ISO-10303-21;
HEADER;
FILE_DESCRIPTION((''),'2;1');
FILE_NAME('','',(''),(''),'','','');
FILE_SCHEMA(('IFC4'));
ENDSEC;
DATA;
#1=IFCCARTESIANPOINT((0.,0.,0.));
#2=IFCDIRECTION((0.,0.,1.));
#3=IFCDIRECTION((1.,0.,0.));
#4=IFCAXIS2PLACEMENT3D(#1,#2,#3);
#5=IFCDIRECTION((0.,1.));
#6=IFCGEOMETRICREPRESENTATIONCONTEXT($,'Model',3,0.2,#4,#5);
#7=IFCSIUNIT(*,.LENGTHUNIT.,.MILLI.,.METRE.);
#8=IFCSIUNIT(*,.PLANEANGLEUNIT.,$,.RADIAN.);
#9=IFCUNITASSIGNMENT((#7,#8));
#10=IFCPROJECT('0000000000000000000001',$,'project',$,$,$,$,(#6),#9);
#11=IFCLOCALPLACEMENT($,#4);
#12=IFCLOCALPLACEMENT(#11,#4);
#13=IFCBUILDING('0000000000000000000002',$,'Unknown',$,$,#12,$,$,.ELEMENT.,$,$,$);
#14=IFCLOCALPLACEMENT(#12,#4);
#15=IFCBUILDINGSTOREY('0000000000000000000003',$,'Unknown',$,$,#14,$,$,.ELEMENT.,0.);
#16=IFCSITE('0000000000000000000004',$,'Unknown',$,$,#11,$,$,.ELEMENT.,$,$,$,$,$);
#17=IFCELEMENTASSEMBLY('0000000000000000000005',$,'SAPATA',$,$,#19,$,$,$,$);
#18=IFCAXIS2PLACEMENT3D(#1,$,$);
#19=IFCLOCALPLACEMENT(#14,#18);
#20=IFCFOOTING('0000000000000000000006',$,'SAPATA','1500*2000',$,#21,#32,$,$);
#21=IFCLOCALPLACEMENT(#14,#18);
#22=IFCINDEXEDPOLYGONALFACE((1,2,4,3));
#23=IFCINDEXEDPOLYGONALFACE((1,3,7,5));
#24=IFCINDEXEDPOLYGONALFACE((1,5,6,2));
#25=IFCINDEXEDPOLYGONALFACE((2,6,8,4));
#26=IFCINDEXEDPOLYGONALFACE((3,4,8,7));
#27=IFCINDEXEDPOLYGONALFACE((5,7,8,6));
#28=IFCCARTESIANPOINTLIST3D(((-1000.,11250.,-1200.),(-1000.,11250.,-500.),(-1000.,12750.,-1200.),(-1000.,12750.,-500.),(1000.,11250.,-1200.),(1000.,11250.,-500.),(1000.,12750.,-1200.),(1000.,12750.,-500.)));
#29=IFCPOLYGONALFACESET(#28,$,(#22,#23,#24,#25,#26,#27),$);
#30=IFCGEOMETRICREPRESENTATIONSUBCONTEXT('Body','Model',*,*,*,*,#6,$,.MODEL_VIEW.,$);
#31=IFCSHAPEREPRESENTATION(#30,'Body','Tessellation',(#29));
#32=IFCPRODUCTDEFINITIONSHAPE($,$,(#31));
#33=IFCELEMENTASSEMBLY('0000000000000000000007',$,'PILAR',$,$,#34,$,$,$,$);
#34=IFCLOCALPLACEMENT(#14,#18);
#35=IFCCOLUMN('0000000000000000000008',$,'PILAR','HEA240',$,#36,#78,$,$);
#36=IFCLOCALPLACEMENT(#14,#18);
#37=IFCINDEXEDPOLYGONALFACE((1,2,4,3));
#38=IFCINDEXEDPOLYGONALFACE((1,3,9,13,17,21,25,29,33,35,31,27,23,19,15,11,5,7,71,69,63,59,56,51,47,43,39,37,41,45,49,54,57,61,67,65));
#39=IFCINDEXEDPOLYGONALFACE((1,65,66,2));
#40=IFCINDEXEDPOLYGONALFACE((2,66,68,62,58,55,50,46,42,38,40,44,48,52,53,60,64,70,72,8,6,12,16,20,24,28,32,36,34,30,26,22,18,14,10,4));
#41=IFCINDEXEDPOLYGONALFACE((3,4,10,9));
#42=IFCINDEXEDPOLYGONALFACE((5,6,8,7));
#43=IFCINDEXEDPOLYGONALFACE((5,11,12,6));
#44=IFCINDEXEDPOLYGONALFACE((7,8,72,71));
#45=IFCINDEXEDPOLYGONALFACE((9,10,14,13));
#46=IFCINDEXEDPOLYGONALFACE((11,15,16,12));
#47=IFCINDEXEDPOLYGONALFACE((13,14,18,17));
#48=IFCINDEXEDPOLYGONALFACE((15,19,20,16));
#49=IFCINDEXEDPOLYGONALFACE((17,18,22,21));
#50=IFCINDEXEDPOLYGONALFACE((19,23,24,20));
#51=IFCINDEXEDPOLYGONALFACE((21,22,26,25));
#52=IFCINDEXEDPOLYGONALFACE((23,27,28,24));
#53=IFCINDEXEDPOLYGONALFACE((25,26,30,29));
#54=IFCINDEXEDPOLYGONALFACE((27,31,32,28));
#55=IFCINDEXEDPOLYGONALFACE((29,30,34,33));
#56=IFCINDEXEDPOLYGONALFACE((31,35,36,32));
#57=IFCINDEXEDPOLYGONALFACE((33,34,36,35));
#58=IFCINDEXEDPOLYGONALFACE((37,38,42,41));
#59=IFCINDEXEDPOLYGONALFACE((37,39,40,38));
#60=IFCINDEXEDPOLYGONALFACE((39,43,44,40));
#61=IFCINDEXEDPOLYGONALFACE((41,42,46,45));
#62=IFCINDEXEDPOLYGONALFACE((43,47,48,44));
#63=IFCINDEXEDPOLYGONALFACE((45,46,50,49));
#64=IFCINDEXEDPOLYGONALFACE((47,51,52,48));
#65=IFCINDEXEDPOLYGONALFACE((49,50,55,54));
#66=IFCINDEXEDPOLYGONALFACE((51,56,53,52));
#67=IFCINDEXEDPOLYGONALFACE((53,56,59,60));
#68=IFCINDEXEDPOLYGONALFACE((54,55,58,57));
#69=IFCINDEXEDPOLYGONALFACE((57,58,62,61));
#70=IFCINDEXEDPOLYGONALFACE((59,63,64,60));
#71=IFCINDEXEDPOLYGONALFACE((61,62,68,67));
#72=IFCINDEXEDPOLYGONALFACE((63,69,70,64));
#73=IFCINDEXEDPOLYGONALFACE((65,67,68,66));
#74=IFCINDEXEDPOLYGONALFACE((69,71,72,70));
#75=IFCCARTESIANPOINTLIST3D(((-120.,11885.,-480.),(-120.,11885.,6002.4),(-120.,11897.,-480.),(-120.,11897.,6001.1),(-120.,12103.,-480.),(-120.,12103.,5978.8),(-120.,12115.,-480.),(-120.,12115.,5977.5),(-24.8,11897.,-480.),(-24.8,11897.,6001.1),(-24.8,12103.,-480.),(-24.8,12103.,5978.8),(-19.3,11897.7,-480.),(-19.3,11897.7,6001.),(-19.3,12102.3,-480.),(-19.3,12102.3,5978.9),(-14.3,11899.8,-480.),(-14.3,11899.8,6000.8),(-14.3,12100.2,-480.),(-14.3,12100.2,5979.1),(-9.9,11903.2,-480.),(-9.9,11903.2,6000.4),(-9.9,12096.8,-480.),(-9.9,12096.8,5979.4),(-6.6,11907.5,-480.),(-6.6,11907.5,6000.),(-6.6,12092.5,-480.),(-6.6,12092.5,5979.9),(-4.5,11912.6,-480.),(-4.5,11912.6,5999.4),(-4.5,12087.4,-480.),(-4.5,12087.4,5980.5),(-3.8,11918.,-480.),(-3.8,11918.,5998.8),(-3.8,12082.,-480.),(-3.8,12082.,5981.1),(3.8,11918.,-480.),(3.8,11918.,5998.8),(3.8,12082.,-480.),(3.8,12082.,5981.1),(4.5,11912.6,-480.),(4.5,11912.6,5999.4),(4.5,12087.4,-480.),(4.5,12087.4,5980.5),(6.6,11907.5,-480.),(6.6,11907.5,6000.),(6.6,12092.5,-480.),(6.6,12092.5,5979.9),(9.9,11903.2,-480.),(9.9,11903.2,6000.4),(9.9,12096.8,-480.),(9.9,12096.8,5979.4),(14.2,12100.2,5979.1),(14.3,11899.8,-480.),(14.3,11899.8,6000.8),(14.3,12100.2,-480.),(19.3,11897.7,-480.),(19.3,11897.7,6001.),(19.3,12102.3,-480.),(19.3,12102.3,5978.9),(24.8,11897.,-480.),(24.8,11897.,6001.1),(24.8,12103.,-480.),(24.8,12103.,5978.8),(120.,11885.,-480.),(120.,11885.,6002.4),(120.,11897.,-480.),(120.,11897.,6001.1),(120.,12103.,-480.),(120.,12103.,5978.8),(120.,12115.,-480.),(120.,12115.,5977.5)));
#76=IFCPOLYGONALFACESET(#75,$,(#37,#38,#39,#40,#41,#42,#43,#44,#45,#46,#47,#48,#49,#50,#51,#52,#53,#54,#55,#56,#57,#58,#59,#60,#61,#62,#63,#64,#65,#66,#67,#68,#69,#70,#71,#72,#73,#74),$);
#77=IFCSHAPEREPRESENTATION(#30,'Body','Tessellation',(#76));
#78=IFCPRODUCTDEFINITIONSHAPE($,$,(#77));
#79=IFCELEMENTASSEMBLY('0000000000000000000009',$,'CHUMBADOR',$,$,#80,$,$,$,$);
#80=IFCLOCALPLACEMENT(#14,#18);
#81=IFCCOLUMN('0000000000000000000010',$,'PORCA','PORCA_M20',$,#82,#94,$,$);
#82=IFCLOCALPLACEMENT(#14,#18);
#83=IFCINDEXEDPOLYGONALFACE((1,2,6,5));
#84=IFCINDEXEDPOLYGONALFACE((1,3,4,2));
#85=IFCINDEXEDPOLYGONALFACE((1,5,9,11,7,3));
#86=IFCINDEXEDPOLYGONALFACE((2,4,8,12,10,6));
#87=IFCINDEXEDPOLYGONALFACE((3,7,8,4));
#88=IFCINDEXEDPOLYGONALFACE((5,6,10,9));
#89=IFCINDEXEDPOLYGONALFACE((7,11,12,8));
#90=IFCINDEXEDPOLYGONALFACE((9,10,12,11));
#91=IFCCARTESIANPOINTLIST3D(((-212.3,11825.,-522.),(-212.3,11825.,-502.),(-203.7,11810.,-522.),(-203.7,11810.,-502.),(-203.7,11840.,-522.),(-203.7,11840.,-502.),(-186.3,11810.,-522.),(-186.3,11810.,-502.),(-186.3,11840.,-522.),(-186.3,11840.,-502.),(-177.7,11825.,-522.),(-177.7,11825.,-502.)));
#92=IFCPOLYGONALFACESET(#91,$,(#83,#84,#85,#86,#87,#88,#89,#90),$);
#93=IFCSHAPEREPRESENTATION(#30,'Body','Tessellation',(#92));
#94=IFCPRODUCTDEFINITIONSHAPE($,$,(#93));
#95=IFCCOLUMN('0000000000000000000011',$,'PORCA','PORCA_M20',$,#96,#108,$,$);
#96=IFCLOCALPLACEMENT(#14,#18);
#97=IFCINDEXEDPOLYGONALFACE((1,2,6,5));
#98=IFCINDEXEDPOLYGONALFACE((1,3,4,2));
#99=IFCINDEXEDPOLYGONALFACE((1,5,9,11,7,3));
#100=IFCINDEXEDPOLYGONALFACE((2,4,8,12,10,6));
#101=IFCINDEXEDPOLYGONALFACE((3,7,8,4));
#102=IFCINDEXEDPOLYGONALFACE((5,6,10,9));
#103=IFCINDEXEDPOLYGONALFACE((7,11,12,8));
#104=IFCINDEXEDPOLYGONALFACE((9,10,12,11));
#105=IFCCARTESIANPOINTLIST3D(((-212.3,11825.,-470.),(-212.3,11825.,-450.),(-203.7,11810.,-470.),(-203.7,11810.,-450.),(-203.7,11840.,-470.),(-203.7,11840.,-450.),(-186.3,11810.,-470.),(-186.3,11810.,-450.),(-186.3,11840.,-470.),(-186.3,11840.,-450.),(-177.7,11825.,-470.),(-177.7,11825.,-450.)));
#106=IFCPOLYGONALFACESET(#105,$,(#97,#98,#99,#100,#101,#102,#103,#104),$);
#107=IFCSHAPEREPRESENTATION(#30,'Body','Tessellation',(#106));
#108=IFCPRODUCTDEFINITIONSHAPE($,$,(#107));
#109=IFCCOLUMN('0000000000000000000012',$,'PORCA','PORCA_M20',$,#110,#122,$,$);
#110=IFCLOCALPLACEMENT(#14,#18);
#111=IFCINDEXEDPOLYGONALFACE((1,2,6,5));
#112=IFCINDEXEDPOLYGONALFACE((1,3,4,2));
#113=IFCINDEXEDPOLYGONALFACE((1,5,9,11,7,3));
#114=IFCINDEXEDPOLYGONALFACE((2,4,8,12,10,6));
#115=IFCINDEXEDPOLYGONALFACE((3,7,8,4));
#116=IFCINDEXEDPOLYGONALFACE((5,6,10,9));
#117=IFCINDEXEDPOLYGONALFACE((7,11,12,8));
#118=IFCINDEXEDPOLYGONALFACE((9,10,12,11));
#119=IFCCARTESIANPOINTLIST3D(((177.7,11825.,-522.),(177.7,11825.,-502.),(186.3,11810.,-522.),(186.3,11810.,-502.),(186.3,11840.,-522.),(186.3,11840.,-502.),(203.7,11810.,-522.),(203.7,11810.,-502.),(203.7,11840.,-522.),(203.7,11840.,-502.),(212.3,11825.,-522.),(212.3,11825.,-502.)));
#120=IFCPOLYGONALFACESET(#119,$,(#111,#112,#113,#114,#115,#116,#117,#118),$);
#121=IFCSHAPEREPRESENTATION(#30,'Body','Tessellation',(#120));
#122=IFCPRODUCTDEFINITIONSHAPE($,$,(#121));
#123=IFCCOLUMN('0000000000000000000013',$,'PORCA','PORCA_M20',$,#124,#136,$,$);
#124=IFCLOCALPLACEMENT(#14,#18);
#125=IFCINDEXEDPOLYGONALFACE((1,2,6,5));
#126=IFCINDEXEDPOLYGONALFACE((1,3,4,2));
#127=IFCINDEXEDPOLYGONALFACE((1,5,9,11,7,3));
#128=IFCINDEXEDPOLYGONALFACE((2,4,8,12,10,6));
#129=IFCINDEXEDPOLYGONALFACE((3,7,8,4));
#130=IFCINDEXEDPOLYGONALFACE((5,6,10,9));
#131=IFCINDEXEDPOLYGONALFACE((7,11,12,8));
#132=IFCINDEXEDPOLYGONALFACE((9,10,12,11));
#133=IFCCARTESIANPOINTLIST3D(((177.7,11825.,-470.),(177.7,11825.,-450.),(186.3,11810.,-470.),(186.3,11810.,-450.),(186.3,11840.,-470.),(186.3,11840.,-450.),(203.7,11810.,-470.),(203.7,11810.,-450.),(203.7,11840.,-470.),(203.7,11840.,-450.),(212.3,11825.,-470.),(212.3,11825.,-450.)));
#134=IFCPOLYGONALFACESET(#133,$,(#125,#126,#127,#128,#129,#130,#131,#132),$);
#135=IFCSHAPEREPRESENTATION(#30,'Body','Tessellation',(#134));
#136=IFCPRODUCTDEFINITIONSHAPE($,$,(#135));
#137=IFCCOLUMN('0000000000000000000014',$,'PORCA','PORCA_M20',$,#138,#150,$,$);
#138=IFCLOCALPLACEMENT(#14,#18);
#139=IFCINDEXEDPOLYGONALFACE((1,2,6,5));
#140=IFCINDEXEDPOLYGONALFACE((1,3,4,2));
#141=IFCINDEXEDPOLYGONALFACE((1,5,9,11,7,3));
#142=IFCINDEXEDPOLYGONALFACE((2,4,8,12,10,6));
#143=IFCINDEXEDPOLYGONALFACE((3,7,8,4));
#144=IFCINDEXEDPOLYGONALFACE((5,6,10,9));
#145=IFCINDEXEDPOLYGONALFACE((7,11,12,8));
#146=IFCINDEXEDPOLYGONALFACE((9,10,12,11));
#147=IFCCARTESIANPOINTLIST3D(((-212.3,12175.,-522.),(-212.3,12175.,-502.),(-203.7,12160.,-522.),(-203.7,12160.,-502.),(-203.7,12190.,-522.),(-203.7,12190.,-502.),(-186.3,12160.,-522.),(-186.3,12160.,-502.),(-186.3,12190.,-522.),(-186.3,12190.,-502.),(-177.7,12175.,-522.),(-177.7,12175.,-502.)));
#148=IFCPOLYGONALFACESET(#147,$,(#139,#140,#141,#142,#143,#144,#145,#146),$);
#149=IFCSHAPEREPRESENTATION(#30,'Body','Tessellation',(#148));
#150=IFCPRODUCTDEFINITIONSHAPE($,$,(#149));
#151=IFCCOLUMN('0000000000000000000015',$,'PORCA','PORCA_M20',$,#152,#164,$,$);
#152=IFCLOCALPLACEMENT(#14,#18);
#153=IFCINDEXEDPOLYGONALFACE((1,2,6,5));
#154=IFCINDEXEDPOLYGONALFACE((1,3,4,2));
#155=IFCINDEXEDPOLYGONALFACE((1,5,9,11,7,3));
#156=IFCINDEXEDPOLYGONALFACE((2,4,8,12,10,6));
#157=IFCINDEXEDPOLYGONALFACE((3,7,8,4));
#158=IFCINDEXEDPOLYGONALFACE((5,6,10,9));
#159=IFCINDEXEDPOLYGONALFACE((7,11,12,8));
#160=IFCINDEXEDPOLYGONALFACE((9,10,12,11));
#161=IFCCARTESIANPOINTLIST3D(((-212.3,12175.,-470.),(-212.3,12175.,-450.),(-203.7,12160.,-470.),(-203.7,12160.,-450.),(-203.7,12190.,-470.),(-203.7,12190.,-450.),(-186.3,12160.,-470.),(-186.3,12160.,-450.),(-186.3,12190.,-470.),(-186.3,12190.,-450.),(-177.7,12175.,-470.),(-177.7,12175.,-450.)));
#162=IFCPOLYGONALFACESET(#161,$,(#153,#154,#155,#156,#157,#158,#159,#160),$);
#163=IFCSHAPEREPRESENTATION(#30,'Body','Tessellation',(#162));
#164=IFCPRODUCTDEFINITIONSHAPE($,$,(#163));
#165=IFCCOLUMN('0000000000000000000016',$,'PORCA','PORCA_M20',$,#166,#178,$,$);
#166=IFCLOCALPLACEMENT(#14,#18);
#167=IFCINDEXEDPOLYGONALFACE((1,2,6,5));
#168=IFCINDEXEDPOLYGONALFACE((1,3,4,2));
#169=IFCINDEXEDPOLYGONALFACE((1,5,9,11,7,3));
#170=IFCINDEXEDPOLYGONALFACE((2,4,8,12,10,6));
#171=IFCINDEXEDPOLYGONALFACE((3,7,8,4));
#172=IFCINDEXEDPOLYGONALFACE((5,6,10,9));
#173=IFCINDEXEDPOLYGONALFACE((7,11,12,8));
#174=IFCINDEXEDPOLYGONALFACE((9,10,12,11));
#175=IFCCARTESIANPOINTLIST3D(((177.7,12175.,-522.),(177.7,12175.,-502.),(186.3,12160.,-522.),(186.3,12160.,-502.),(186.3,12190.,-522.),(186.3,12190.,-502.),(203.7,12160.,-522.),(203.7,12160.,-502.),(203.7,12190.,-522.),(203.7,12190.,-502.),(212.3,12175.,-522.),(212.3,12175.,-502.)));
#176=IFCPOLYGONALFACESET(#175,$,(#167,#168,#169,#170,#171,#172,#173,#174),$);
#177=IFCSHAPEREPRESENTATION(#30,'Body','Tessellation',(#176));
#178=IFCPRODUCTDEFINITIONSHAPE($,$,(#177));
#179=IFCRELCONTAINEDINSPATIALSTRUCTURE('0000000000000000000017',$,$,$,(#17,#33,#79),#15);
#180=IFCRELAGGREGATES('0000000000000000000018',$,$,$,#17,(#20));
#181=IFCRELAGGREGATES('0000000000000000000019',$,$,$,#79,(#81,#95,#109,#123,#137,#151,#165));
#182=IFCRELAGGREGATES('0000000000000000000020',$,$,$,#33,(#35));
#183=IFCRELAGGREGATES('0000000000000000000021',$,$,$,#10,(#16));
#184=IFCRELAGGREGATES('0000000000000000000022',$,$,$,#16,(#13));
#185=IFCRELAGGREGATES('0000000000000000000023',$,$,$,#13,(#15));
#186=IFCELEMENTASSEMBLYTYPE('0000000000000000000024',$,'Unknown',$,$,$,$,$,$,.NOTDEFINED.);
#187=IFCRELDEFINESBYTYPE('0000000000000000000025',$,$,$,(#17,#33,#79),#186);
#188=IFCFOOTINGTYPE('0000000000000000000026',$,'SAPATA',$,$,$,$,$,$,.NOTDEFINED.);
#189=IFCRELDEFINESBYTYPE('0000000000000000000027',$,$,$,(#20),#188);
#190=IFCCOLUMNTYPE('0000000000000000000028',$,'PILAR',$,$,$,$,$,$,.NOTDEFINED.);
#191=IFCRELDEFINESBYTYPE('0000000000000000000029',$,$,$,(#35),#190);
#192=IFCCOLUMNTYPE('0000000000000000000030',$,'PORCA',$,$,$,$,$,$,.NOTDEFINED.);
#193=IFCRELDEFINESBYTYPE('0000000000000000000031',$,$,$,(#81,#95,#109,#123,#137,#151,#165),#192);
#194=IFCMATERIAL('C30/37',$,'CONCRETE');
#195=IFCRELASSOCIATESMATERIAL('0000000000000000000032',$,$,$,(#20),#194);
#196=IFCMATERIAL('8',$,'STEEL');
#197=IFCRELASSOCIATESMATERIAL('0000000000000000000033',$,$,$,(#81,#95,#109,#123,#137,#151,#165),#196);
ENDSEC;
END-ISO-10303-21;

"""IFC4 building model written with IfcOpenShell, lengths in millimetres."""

from ifc_helpers import new_model, si_unit, direction, frame, origin_with_axes, origin_2d_with_axis, place, context, subcontext, project, spatial, polyline, rectangle, i_section, outline, extrude, clip, halfspace, material, material_profile, profile_set, profile_usage, type_object, element, aggregate, save


model = new_model("IFC4")

# Units and contexts
model_context = context("Model", 3, precision=0.2, world=origin_with_axes(), true_north=direction((0.0, 1.0)))
body_context = subcontext(model_context, "Body", "Model", "MODEL_VIEW")
ifc_project = project(units=[si_unit("LENGTHUNIT", "METRE", prefix="MILLI"), si_unit("PLANEANGLEUNIT", "RADIAN")], contexts=[model_context])

# Site, building, storey
site_placement = place(None, origin_with_axes())
site = spatial("IfcSite", under=ifc_project, at=site_placement, Name="Unknown", CompositionType="ELEMENT")
building_placement = place(site_placement, origin_with_axes())
building = spatial("IfcBuilding", under=site, at=building_placement, Name="Unknown", CompositionType="ELEMENT")
storey_placement = place(building_placement, origin_with_axes())
storey = spatial("IfcBuildingStorey", under=building, at=storey_placement, Name="Unknown", CompositionType="ELEMENT", Elevation=0.0)

# Element assembly, footing
element_assembly_type = type_object("IfcElementAssemblyType", Name="Unknown", PredefinedType="NOTDEFINED")
assembly_1_placement = place(storey_placement, frame((0.0, 12000.0, -1200.0), z_axis=(-1.0, 0.0, 0.0), x_axis=(0.0, 0.0, 1.0)))
assembly_1 = element("IfcElementAssembly", 1, at=assembly_1_placement, inside=storey, type_object=element_assembly_type, Name="SAPATA")
ifc_material_1 = material(Name="C30/37", Category="CONCRETE")
ifc_material_profile_1 = material_profile(ifc_material_1, rectangle(XDim=2000.0, YDim=1500.0, at=origin_2d_with_axis()), Name="1500*2000")
ifc_profile_set_1 = profile_set([ifc_material_profile_1])
ifc_profile_usage_1 = profile_usage(ifc_profile_set_1, cardinal=5)
footing_type = type_object("IfcFootingType", Name="SAPATA", PredefinedType="NOTDEFINED")
footing_placement = place(assembly_1_placement, origin_with_axes())
footing = element("IfcFooting", 2, at=footing_placement, type_object=footing_type, material=ifc_profile_usage_1, Name="SAPATA", Description="1500*2000", context=body_context, shape_type="SolidModel", body=[
    extrude(rectangle(XDim=2000.0, YDim=1500.0, at=origin_2d_with_axis()), frame((0.0, 0.0, 0.0), z_axis=(-1.0, 0.0, 0.0), x_axis=(0.0, 0.0, 1.0)), (0.0, 0.0, -1.0), 700.0),
])
aggregate(assembly_1, [footing])

# Element assembly, column
assembly_2_placement = place(storey_placement, frame((0.0, 12000.0, -500.0), z_axis=(-1.0, 0.0, 0.0), x_axis=(0.0, 0.0, 1.0)))
assembly_2 = element("IfcElementAssembly", 3, at=assembly_2_placement, inside=storey, type_object=element_assembly_type, Name="PILAR")
column_type_1 = type_object("IfcColumnType", Name="PILAR", PredefinedType="NOTDEFINED")
column_1_placement = place(assembly_2_placement, origin_with_axes())
column_1 = element("IfcColumn", 4, at=column_1_placement, type_object=column_type_1, Name="PILAR", Description="HEA240", context=body_context, shape_type="Clipping", body=[
    clip(clip(extrude(i_section(OverallWidth=240.0, OverallDepth=230.0, WebThickness=7.5, FlangeThickness=12.0, FilletRadius=21.0, FlangeEdgeRadius=0.0, FlangeSlope=0.0, at=origin_2d_with_axis()), frame((-220.0, 0.0, 0.0), z_axis=(-1.0, 0.0, 0.0), x_axis=(0.0, 0.0, 1.0)), (0.0, 0.0, -1.0), 6949.9), halfspace(frame((20.0, -115.0, 0.0), z_axis=(1.0, 0.0, 0.0), x_axis=(0.0, 1.0, 0.0)), True)), halfspace(frame((6477.5, 115.0, 0.0), z_axis=(-0.994183, -0.107703, 0.0), x_axis=(0.107703, -0.994183, 0.0)), True)),
])

# Element assembly, columns
assembly_3_placement = place(storey_placement, frame((195.0, 12175.0, -555.0), z_axis=(-1.0, 0.0, 0.0), x_axis=(0.0, 0.0, -1.0)))
assembly_3 = element("IfcElementAssembly", 5, at=assembly_3_placement, inside=storey, type_object=element_assembly_type, Name="CHUMBADOR")
ifc_material_2 = material(Name="8", Category="STEEL")
ifc_material_profile_2 = material_profile(ifc_material_2, outline(polyline([(8.7, -15.0), (17.3, 0.0), (8.7, 15.0), (-8.7, 15.0), (-17.3, 0.0), (-8.7, -15.0), (8.7, -15.0)])), Name="PORCA_M20")
ifc_profile_set_2 = profile_set([ifc_material_profile_2])
ifc_profile_usage_2 = profile_usage(ifc_profile_set_2, cardinal=5)
column_type_2 = type_object("IfcColumnType", Name="PORCA", PredefinedType="NOTDEFINED")
column_2_placement = place(assembly_3_placement, frame((-53.0, 350.0, 390.0), z_axis=(0.0, 0.0, 1.0), x_axis=(1.0, 0.0, 0.0)))
column_2 = element("IfcColumn", 6, at=column_2_placement, type_object=column_type_2, material=ifc_profile_usage_2, Name="PORCA", Description="PORCA_M20", context=body_context, shape_type="SolidModel", body=[
    extrude(outline(polyline([(8.7, -15.0), (17.3, 0.0), (8.7, 15.0), (-8.7, 15.0), (-17.3, 0.0), (-8.7, -15.0), (8.7, -15.0)])), frame((0.0, 0.0, 0.0), z_axis=(-1.0, 0.0, 0.0), x_axis=(0.0, 0.0, 1.0)), (0.0, 0.0, -1.0), 20.0),
])
column_3_placement = place(assembly_3_placement, frame((-105.0, 350.0, 390.0), z_axis=(0.0, 0.0, 1.0), x_axis=(1.0, 0.0, 0.0)))
column_3 = element("IfcColumn", 7, at=column_3_placement, type_object=column_type_2, material=ifc_profile_usage_2, Name="PORCA", Description="PORCA_M20", context=body_context, shape_type="SolidModel", body=[
    extrude(outline(polyline([(8.7, -15.0), (17.3, 0.0), (8.7, 15.0), (-8.7, 15.0), (-17.3, 0.0), (-8.7, -15.0), (8.7, -15.0)])), frame((0.0, 0.0, 0.0), z_axis=(-1.0, 0.0, 0.0), x_axis=(0.0, 0.0, 1.0)), (0.0, 0.0, -1.0), 20.0),
])
column_4_placement = place(assembly_3_placement, frame((-53.0, 350.0, 0.0), z_axis=(0.0, 0.0, -1.0), x_axis=(1.0, 0.0, 0.0)))
column_4 = element("IfcColumn", 8, at=column_4_placement, type_object=column_type_2, material=ifc_profile_usage_2, Name="PORCA", Description="PORCA_M20", context=body_context, shape_type="SolidModel", body=[
    extrude(outline(polyline([(8.7, -15.0), (17.3, 0.0), (8.7, 15.0), (-8.7, 15.0), (-17.3, 0.0), (-8.7, -15.0), (8.7, -15.0)])), frame((0.0, 0.0, 0.0), z_axis=(-1.0, 0.0, 0.0), x_axis=(0.0, 0.0, 1.0)), (0.0, 0.0, -1.0), 20.0),
])
column_5_placement = place(assembly_3_placement, frame((-105.0, 350.0, 0.0), z_axis=(0.0, 0.0, -1.0), x_axis=(1.0, 0.0, 0.0)))
column_5 = element("IfcColumn", 9, at=column_5_placement, type_object=column_type_2, material=ifc_profile_usage_2, Name="PORCA", Description="PORCA_M20", context=body_context, shape_type="SolidModel", body=[
    extrude(outline(polyline([(8.7, -15.0), (17.3, 0.0), (8.7, 15.0), (-8.7, 15.0), (-17.3, 0.0), (-8.7, -15.0), (8.7, -15.0)])), frame((0.0, 0.0, 0.0), z_axis=(-1.0, 0.0, 0.0), x_axis=(0.0, 0.0, 1.0)), (0.0, 0.0, -1.0), 20.0),
])
column_6_placement = place(assembly_3_placement, frame((-53.0, 0.0, 390.0), z_axis=(0.0, 0.0, 1.0), x_axis=(1.0, 0.0, 0.0)))
column_6 = element("IfcColumn", 10, at=column_6_placement, type_object=column_type_2, material=ifc_profile_usage_2, Name="PORCA", Description="PORCA_M20", context=body_context, shape_type="SolidModel", body=[
    extrude(outline(polyline([(8.7, -15.0), (17.3, 0.0), (8.7, 15.0), (-8.7, 15.0), (-17.3, 0.0), (-8.7, -15.0), (8.7, -15.0)])), frame((0.0, 0.0, 0.0), z_axis=(-1.0, 0.0, 0.0), x_axis=(0.0, 0.0, 1.0)), (0.0, 0.0, -1.0), 20.0),
])
column_7_placement = place(assembly_3_placement, frame((-105.0, 0.0, 390.0), z_axis=(0.0, 0.0, 1.0), x_axis=(1.0, 0.0, 0.0)))
column_7 = element("IfcColumn", 11, at=column_7_placement, type_object=column_type_2, material=ifc_profile_usage_2, Name="PORCA", Description="PORCA_M20", context=body_context, shape_type="SolidModel", body=[
    extrude(outline(polyline([(8.7, -15.0), (17.3, 0.0), (8.7, 15.0), (-8.7, 15.0), (-17.3, 0.0), (-8.7, -15.0), (8.7, -15.0)])), frame((0.0, 0.0, 0.0), z_axis=(-1.0, 0.0, 0.0), x_axis=(0.0, 0.0, 1.0)), (0.0, 0.0, -1.0), 20.0),
])
column_8_placement = place(assembly_3_placement, frame((-53.0, 0.0, 0.0), z_axis=(0.0, 0.0, -1.0), x_axis=(1.0, 0.0, 0.0)))
column_8 = element("IfcColumn", 12, at=column_8_placement, type_object=column_type_2, material=ifc_profile_usage_2, Name="PORCA", Description="PORCA_M20", context=body_context, shape_type="SolidModel", body=[
    extrude(outline(polyline([(8.7, -15.0), (17.3, 0.0), (8.7, 15.0), (-8.7, 15.0), (-17.3, 0.0), (-8.7, -15.0), (8.7, -15.0)])), frame((0.0, 0.0, 0.0), z_axis=(-1.0, 0.0, 0.0), x_axis=(0.0, 0.0, 1.0)), (0.0, 0.0, -1.0), 20.0),
])
aggregate(assembly_3, [column_2, column_3, column_4, column_5, column_6, column_7, column_8])

aggregate(assembly_2, [column_1])

save(model, "model.ifc")
